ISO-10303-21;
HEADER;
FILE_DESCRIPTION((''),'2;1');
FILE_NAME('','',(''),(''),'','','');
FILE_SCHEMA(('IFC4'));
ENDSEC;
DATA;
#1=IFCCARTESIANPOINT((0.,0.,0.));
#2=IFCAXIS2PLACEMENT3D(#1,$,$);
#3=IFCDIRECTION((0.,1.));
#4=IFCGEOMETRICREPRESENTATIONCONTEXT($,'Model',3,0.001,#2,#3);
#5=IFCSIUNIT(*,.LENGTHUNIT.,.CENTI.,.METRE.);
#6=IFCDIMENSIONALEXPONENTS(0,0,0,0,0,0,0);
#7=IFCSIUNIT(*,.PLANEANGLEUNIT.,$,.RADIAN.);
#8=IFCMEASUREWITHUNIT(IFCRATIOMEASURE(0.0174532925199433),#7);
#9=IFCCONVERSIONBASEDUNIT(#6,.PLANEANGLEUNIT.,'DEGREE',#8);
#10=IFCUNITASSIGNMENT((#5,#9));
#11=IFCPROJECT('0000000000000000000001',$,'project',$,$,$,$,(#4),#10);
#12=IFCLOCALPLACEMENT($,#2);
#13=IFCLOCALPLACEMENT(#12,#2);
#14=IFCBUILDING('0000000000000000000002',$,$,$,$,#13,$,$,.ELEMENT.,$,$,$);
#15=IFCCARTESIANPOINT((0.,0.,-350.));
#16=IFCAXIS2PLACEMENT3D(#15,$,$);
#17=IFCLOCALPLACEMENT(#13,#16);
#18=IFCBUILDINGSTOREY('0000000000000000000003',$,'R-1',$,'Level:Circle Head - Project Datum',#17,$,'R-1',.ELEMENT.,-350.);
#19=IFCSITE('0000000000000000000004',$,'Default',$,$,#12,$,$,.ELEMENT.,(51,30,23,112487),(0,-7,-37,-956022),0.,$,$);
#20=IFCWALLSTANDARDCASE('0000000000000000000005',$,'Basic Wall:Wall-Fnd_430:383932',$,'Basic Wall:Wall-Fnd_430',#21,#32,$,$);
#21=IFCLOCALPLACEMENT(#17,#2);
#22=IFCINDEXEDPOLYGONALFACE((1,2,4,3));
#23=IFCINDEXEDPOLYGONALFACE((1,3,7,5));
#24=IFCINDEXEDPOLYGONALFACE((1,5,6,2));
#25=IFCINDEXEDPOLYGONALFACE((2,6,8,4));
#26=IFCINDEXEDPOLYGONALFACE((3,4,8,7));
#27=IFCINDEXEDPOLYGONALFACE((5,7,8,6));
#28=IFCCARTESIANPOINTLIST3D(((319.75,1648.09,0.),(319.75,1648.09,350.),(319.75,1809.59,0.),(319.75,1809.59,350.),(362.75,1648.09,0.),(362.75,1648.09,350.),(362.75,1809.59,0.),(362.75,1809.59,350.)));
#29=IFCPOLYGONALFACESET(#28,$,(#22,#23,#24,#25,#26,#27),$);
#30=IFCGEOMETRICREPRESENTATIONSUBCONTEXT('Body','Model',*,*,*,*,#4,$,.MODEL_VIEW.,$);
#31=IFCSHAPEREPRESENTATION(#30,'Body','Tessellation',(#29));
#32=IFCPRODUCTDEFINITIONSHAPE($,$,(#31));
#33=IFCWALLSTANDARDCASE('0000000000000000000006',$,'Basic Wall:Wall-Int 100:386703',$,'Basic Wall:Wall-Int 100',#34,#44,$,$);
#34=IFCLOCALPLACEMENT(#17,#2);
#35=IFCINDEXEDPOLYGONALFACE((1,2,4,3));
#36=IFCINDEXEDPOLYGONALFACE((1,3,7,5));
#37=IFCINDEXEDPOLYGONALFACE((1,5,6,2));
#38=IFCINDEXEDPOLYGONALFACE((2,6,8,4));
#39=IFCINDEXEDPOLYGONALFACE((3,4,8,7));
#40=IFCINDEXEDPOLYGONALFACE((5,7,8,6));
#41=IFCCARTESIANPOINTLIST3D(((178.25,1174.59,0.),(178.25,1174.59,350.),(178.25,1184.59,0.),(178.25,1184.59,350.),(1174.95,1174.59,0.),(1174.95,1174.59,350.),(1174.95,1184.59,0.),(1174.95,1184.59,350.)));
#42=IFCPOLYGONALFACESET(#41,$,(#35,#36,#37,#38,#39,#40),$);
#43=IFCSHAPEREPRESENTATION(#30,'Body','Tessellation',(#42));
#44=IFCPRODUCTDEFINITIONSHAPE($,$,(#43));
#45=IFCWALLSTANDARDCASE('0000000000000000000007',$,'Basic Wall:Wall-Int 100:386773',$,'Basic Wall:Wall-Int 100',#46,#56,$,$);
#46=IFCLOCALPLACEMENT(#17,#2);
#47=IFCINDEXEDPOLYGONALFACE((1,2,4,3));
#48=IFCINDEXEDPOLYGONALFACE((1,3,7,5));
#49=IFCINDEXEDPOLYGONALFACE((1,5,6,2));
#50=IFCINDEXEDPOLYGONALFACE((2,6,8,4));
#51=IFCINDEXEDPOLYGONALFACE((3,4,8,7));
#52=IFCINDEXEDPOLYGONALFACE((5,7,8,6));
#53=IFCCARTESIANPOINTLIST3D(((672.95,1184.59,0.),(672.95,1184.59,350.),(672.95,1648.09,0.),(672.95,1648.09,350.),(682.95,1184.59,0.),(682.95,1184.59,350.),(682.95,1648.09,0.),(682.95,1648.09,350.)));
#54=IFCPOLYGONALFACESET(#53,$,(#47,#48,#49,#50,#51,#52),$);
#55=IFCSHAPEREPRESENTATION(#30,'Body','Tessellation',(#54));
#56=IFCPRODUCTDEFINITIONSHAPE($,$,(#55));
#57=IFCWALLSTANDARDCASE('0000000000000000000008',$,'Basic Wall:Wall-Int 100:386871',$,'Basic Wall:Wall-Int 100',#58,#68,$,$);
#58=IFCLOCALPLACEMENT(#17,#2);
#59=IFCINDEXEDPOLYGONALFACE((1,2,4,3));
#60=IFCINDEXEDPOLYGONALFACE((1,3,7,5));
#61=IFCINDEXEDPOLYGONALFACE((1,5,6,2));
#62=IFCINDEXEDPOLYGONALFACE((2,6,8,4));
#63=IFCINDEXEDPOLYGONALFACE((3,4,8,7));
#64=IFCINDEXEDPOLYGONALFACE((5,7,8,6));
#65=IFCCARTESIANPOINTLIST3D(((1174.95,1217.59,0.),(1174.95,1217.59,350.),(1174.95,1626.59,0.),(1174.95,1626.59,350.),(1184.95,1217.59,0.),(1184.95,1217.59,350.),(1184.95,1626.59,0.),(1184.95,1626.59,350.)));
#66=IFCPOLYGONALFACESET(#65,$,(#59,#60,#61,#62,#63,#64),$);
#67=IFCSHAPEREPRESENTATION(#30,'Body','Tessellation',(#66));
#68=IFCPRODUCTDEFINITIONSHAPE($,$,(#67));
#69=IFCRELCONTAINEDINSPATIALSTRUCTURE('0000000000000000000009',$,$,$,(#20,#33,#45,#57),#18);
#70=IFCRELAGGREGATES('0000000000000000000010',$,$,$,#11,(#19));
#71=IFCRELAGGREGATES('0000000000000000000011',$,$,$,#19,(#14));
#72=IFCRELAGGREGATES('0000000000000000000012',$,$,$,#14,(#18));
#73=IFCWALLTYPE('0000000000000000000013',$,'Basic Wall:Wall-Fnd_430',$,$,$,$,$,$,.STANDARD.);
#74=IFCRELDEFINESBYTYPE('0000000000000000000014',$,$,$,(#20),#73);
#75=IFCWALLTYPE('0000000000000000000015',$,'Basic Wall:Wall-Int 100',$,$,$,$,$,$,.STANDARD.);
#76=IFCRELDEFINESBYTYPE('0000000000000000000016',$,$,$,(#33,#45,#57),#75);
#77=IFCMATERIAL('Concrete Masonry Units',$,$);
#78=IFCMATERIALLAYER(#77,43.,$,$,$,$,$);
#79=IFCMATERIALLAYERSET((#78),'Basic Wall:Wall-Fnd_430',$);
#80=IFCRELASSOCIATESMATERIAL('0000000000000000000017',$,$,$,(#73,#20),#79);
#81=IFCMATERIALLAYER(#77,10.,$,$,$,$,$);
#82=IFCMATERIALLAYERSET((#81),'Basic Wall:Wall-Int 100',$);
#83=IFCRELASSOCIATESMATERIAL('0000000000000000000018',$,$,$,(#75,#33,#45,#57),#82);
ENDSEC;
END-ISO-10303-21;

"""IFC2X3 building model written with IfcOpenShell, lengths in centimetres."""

from ifc_helpers import new_model, entity, si_unit, converted_unit, direction, frame, frame_2d, origin, place, context, subcontext, project, spatial, rectangle, extrude, material, layer, layer_set, layer_usage, type_object, element, save


model = new_model("IFC2X3")

# Units and contexts
model_context = context("Model", 3, precision=0.001, world=origin(), true_north=direction((0.0, 1.0)))
body_context = subcontext(model_context, "Body", "Model", "MODEL_VIEW")
ifc_project = project(units=[si_unit("LENGTHUNIT", "METRE", prefix="CENTI"), converted_unit("PLANEANGLEUNIT", "DEGREE", entity("IfcRatioMeasure", 0.0174532925199433), si_unit("PLANEANGLEUNIT", "RADIAN"), dimensions=[0, 0, 0, 0, 0, 0, 0])], contexts=[model_context])

# Site, building, storey
site_placement = place(None, origin())
site = spatial("IfcSite", under=ifc_project, at=site_placement, Name="Default", CompositionType="ELEMENT", RefLatitude=(51, 30, 23, 112487), RefLongitude=(0, -7, -37, -956022), RefElevation=0.0)
building_placement = place(site_placement, origin())
building = spatial("IfcBuilding", under=site, at=building_placement, CompositionType="ELEMENT")
storey_placement = place(building_placement, frame((0.0, 0.0, -350.0)))
storey = spatial("IfcBuildingStorey", under=building, at=storey_placement, Name="R-1", ObjectType="Level:Circle Head - Project Datum", LongName="R-1", CompositionType="ELEMENT", Elevation=-350.0)

# Walls
ifc_material_1 = material(Name="Concrete Masonry Units")
ifc_layer_1 = layer(ifc_material_1, 43.0)
ifc_layer_set_1 = layer_set([ifc_layer_1], Name="Basic Wall:Wall-Fnd_430")
wall_type_1 = type_object("IfcWallType", Name="Basic Wall:Wall-Fnd_430", PredefinedType="STANDARD", material=ifc_layer_set_1)
ifc_layer_usage_1 = layer_usage(ifc_layer_set_1, "AXIS2", "NEGATIVE", 21.5)
wall_1_placement = place(storey_placement, frame((341.25, 1648.09, 0.0), z_axis=(0.0, 0.0, 1.0), x_axis=(0.0, 1.0, 0.0)))
element("IfcWallStandardCase", 1, at=wall_1_placement, inside=storey, type_object=wall_type_1, material=ifc_layer_usage_1, Name="Basic Wall:Wall-Fnd_430:383932", ObjectType="Basic Wall:Wall-Fnd_430", context=body_context, shape_type="SweptSolid", body=[
    extrude(rectangle(XDim=161.5, YDim=43.0, at=frame_2d((80.75, 0.0), x_axis=(-1.0, 0.0))), origin(), (0.0, 0.0, 1.0), 350.0),
])
ifc_layer_2 = layer(ifc_material_1, 10.0)
ifc_layer_set_2 = layer_set([ifc_layer_2], Name="Basic Wall:Wall-Int 100")
ifc_layer_usage_2 = layer_usage(ifc_layer_set_2, "AXIS2", "NEGATIVE", 5.0)
wall_type_2 = type_object("IfcWallType", Name="Basic Wall:Wall-Int 100", PredefinedType="STANDARD", material=ifc_layer_set_2)
wall_2_placement = place(storey_placement, frame((1174.95, 1179.59, 0.0), z_axis=(0.0, 0.0, 1.0), x_axis=(-1.0, 0.0, 0.0)))
element("IfcWallStandardCase", 2, at=wall_2_placement, inside=storey, type_object=wall_type_2, material=ifc_layer_usage_2, Name="Basic Wall:Wall-Int 100:386703", ObjectType="Basic Wall:Wall-Int 100", context=body_context, shape_type="SweptSolid", body=[
    extrude(rectangle(XDim=996.7, YDim=10.0, at=frame_2d((498.35, 0.0), x_axis=(-1.0, 0.0))), origin(), (0.0, 0.0, 1.0), 350.0),
])
ifc_layer_usage_3 = layer_usage(ifc_layer_set_2, "AXIS2", "POSITIVE", -5.0)
wall_3_placement = place(storey_placement, frame((677.95, 1184.59, 0.0), z_axis=(0.0, 0.0, 1.0), x_axis=(0.0, 1.0, 0.0)))
element("IfcWallStandardCase", 3, at=wall_3_placement, inside=storey, type_object=wall_type_2, material=ifc_layer_usage_3, Name="Basic Wall:Wall-Int 100:386773", ObjectType="Basic Wall:Wall-Int 100", context=body_context, shape_type="SweptSolid", body=[
    extrude(rectangle(XDim=463.5, YDim=10.0, at=frame_2d((231.75, 0.0), x_axis=(-1.0, 0.0))), origin(), (0.0, 0.0, 1.0), 350.0),
])
ifc_layer_usage_4 = layer_usage(ifc_layer_set_2, "AXIS2", "NEGATIVE", 5.0)
wall_4_placement = place(storey_placement, frame((1179.95, 1217.59, 0.0), z_axis=(0.0, 0.0, 1.0), x_axis=(0.0, 1.0, 0.0)))
element("IfcWallStandardCase", 4, at=wall_4_placement, inside=storey, type_object=wall_type_2, material=ifc_layer_usage_4, Name="Basic Wall:Wall-Int 100:386871", ObjectType="Basic Wall:Wall-Int 100", context=body_context, shape_type="SweptSolid", body=[
    extrude(rectangle(XDim=409.0, YDim=10.0, at=frame_2d((204.5, 0.0), x_axis=(-1.0, 0.0))), origin(), (0.0, 0.0, 1.0), 350.0),
])

save(model, "model.ifc")
